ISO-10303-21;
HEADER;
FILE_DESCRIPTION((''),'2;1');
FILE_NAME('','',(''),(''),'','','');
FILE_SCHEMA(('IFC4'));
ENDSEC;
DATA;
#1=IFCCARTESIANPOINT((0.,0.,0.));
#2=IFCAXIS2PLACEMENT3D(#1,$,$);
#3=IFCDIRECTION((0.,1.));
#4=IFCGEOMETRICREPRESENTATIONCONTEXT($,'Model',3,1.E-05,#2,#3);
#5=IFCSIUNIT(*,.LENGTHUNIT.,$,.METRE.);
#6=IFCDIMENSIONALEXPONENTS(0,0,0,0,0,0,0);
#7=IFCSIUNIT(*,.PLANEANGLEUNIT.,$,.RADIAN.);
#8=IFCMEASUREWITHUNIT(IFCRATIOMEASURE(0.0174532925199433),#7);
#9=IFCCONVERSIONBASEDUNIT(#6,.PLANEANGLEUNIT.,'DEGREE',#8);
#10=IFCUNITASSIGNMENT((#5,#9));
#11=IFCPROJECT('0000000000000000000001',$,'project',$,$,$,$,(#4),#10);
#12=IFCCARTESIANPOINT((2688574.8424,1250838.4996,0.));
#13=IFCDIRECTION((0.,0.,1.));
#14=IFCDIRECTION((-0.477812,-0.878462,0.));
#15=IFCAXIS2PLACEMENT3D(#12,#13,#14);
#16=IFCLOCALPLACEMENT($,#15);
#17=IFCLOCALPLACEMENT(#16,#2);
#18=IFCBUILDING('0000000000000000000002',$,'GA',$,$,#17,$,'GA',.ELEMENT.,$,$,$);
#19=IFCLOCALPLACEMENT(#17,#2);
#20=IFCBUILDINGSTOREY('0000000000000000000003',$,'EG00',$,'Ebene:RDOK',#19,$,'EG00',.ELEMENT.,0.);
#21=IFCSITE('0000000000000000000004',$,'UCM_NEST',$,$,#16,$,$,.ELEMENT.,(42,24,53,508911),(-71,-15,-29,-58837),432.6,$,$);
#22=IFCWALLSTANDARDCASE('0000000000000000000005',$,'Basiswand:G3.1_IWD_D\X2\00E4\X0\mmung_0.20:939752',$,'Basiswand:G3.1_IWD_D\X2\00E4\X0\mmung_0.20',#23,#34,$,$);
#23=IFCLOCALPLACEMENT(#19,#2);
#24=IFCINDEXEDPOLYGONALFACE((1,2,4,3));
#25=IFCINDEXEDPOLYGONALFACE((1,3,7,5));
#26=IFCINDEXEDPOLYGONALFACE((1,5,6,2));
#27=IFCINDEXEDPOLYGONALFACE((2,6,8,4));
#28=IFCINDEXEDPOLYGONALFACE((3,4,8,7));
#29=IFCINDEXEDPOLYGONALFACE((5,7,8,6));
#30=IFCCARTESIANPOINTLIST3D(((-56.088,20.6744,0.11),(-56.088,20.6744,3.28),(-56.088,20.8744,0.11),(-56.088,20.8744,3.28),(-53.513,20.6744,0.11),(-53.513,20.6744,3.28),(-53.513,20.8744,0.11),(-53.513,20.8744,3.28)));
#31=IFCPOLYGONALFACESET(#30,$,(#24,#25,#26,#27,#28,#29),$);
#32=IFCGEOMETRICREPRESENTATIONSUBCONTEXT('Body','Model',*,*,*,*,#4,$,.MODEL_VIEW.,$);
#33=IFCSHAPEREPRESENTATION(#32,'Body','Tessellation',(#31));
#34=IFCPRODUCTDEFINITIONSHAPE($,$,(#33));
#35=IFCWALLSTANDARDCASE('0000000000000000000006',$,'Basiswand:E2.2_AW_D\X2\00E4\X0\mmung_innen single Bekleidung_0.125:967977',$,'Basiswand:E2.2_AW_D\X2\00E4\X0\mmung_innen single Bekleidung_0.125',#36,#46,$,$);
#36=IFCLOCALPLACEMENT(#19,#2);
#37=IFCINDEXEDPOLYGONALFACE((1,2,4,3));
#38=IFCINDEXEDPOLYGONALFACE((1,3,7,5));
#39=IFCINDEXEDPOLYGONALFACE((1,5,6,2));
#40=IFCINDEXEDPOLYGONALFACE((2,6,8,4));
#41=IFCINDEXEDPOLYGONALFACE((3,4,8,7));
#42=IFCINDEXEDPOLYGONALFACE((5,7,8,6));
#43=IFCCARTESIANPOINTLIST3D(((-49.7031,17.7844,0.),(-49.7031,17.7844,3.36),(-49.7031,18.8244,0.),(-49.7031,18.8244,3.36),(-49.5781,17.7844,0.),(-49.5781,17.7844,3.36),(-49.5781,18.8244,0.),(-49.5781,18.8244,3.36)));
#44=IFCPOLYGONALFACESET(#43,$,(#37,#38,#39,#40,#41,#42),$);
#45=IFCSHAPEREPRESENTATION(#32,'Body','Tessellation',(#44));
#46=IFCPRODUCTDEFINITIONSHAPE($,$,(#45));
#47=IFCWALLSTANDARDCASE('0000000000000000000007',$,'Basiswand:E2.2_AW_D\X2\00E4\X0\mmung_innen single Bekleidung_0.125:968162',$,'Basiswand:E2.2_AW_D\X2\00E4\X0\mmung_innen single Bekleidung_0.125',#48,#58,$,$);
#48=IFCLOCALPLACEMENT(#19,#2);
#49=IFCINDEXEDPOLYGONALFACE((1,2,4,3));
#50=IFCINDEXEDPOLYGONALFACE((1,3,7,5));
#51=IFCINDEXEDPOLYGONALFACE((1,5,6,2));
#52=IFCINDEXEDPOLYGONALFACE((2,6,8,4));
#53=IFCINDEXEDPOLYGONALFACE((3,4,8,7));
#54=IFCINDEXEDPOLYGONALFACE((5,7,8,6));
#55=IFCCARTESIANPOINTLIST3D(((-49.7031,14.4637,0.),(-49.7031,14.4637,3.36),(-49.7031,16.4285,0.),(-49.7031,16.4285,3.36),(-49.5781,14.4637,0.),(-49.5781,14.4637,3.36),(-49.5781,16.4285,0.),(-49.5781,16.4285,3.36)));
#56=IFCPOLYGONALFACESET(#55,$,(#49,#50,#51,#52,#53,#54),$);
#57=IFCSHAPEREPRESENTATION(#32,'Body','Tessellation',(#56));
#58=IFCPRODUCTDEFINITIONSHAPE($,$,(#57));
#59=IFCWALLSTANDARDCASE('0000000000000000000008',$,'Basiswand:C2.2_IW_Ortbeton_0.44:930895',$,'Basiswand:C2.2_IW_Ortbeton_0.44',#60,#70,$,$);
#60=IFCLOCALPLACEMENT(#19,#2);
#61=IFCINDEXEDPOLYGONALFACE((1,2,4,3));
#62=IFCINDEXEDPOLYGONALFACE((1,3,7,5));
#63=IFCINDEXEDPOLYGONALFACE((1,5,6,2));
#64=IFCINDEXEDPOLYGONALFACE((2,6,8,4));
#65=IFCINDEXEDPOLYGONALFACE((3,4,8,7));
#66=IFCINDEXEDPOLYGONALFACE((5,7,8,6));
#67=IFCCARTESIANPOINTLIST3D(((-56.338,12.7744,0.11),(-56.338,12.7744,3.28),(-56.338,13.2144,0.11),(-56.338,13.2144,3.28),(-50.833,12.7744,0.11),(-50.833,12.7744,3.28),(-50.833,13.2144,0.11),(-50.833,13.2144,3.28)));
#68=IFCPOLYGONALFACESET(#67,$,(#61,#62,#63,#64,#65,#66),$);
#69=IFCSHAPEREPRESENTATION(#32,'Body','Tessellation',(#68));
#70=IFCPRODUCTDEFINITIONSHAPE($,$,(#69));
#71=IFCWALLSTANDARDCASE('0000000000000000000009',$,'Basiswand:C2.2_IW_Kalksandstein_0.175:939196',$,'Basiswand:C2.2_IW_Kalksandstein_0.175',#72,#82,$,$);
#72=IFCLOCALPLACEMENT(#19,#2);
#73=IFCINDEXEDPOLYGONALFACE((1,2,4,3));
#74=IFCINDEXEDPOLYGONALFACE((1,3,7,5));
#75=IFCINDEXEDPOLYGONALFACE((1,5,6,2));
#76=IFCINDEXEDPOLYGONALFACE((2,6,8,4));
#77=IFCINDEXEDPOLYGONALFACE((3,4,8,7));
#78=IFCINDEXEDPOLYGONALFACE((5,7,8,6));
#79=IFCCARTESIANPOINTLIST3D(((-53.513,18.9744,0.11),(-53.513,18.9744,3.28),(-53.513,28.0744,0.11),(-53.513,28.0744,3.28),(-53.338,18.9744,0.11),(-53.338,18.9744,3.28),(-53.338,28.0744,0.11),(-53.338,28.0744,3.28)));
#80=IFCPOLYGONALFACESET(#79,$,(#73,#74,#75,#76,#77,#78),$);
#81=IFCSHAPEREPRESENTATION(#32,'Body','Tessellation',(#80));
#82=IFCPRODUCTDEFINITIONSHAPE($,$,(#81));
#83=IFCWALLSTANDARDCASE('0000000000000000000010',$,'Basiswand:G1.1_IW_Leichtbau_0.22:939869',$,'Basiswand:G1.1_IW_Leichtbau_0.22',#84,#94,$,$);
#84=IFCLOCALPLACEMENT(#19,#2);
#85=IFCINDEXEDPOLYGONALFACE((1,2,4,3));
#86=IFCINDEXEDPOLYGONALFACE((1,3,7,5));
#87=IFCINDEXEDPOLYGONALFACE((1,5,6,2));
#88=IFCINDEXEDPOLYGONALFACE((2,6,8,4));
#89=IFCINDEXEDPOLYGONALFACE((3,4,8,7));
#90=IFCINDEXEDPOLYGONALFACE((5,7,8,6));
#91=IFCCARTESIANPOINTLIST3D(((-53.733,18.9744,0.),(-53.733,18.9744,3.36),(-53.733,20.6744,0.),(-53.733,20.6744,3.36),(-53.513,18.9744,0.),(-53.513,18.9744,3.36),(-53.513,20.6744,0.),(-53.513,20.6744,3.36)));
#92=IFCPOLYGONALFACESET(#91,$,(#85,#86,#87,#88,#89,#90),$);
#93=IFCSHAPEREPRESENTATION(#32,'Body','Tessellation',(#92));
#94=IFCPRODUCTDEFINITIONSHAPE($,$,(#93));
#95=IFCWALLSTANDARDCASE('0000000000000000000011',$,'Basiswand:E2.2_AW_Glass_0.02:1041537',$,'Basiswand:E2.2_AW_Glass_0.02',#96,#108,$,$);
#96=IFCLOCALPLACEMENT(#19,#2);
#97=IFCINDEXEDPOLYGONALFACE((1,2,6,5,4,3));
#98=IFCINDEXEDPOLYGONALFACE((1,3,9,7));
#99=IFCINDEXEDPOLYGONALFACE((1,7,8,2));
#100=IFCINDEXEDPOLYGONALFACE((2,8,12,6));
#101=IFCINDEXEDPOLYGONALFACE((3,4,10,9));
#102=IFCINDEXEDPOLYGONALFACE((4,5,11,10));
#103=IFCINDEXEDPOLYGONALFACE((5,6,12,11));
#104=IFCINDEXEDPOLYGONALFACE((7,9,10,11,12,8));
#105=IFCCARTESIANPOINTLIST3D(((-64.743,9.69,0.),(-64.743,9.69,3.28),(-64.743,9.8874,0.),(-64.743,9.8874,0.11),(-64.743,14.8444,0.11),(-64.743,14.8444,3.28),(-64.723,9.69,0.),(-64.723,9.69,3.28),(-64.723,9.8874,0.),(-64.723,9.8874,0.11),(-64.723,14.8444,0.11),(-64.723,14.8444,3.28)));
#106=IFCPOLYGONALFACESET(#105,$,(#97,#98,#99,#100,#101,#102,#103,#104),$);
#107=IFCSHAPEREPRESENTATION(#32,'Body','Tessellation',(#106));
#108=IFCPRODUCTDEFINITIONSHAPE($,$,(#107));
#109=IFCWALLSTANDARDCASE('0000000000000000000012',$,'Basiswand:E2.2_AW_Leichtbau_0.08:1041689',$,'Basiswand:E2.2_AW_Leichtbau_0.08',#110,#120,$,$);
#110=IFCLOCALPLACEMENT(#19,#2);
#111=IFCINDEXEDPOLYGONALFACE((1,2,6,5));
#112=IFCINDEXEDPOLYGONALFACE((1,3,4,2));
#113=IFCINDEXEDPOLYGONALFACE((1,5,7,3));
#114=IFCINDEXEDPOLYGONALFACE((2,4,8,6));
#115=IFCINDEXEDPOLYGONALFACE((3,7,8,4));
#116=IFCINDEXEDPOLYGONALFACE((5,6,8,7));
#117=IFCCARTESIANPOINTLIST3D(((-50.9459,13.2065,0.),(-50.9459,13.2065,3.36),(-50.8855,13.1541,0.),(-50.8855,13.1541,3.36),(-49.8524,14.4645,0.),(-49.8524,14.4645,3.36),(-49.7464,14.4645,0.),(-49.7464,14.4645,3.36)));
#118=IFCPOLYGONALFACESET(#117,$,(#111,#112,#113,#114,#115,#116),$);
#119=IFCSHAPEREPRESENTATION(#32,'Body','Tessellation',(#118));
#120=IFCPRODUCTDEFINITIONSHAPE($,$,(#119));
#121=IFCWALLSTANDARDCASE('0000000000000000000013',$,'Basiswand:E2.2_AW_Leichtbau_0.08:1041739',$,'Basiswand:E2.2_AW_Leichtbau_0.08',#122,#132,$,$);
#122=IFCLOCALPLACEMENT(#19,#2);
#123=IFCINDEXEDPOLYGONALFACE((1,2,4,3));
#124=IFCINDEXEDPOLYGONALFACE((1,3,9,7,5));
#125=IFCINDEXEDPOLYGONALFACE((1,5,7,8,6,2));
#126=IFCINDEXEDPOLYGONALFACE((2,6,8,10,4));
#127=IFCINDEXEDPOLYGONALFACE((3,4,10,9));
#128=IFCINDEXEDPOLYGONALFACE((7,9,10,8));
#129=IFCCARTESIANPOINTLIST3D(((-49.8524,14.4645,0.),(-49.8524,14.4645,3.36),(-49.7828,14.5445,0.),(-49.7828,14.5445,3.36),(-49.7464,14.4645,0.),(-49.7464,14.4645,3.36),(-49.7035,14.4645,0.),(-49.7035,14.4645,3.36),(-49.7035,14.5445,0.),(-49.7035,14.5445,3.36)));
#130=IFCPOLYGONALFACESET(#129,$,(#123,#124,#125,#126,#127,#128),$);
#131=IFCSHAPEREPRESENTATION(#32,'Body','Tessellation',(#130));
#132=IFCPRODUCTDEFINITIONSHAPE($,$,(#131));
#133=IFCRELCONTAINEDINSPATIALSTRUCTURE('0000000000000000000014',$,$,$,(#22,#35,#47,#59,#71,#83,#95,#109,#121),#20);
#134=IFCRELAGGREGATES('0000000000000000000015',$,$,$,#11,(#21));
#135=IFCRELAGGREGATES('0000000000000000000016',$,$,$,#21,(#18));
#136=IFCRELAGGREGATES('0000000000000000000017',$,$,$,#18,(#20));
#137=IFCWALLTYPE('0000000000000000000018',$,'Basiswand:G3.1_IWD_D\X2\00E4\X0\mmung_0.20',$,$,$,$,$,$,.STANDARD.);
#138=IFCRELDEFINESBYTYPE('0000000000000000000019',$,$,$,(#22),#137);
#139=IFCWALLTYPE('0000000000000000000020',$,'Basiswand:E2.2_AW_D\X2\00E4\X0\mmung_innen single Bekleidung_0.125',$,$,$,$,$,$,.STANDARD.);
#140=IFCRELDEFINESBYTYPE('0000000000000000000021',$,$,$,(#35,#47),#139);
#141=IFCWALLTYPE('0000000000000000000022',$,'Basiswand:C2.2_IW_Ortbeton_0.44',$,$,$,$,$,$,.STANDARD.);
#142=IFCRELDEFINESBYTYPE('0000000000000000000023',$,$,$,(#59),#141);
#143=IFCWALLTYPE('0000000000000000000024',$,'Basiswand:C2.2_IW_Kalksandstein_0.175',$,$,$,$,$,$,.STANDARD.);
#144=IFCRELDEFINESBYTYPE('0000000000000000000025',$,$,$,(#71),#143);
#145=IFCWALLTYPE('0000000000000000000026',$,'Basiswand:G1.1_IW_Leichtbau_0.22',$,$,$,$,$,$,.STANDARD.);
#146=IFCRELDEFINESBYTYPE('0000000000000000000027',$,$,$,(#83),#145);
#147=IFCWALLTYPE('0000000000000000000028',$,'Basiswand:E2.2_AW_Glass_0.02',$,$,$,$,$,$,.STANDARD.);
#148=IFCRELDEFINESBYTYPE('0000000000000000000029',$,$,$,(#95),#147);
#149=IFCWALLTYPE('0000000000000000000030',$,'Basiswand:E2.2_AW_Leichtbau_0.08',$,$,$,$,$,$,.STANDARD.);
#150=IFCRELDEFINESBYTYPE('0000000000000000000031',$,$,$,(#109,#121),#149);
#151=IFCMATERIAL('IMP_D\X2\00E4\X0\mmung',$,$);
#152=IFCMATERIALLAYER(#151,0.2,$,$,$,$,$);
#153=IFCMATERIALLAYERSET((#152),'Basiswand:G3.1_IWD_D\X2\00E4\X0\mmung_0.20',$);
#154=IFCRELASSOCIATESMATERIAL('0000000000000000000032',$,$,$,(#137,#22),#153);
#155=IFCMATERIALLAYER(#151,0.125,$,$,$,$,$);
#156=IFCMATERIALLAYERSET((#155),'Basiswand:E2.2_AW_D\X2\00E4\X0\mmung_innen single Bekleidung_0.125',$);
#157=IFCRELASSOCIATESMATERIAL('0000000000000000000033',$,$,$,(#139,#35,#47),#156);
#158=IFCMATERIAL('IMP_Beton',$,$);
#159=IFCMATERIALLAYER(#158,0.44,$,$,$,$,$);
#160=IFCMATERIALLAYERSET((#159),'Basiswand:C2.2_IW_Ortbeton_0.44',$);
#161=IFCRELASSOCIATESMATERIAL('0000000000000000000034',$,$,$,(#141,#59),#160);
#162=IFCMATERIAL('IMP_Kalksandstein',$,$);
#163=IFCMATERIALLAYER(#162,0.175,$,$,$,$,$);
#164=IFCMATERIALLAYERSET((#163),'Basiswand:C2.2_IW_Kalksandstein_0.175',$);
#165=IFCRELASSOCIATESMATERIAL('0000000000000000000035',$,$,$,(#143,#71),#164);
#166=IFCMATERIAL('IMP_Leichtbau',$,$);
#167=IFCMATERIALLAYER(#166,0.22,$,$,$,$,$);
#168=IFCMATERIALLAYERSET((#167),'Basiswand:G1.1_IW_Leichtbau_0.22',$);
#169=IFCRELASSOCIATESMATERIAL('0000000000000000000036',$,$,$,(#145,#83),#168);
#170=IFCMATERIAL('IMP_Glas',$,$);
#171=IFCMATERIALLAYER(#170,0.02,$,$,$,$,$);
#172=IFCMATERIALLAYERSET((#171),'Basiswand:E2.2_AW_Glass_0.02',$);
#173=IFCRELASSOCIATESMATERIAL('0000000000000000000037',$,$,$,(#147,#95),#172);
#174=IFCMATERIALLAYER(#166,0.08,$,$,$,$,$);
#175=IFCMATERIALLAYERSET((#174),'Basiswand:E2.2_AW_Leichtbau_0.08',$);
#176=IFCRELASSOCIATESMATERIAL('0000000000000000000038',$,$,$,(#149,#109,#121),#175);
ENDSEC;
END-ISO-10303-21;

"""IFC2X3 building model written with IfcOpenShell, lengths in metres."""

from ifc_helpers import new_model, entity, si_unit, converted_unit, direction, frame, frame_2d, origin, place, context, subcontext, project, spatial, polyline, rectangle, outline, extrude, clip, bounded_halfspace, material, layer, layer_set, layer_usage, type_object, element, save


model = new_model("IFC2X3")

# Units and contexts
model_context = context("Model", 3, precision=1e-05, world=origin(), true_north=direction((0.0, 1.0)))
body_context = subcontext(model_context, "Body", "Model", "MODEL_VIEW")
ifc_project = project(units=[si_unit("LENGTHUNIT", "METRE"), converted_unit("PLANEANGLEUNIT", "DEGREE", entity("IfcRatioMeasure", 0.0174532925199433), si_unit("PLANEANGLEUNIT", "RADIAN"), dimensions=[0, 0, 0, 0, 0, 0, 0])], contexts=[model_context])

# Site, building, storey
site_placement = place(None, frame((2688574.8424, 1250838.4996, 0.0), z_axis=(0.0, 0.0, 1.0), x_axis=(-0.477812, -0.878462, 0.0)))
site = spatial("IfcSite", under=ifc_project, at=site_placement, Name="UCM_NEST", CompositionType="ELEMENT", RefLatitude=(42, 24, 53, 508911), RefLongitude=(-71, -15, -29, -58837), RefElevation=432.6)
building_placement = place(site_placement, origin())
building = spatial("IfcBuilding", under=site, at=building_placement, Name="GA", LongName="GA", CompositionType="ELEMENT")
storey_placement = place(building_placement, origin())
storey = spatial("IfcBuildingStorey", under=building, at=storey_placement, Name="EG00", ObjectType="Ebene:RDOK", LongName="EG00", CompositionType="ELEMENT", Elevation=0.0)

# Shared definitions
ifc_material_1 = material(Name="IMP_Beton")

# Shared definitions
ifc_material_2 = material(Name="IMP_Glas")

# Shared definitions
ifc_material_3 = material(Name="IMP_Dämmung")

# Walls
ifc_layer_1 = layer(ifc_material_3, 0.2)
ifc_layer_set_1 = layer_set([ifc_layer_1], Name="Basiswand:G3.1_IWD_Dämmung_0.20")
ifc_layer_usage_1 = layer_usage(ifc_layer_set_1, "AXIS2", "NEGATIVE", 0.1)
wall_type_1 = type_object("IfcWallType", Name="Basiswand:G3.1_IWD_Dämmung_0.20", PredefinedType="STANDARD", material=ifc_layer_set_1)
wall_1_placement = place(storey_placement, frame((-53.513, 20.7744, 0.11), z_axis=(0.0, 0.0, 1.0), x_axis=(-1.0, 0.0, 0.0)))
element("IfcWallStandardCase", 1, at=wall_1_placement, inside=storey, type_object=wall_type_1, material=ifc_layer_usage_1, Name="Basiswand:G3.1_IWD_Dämmung_0.20:939752", ObjectType="Basiswand:G3.1_IWD_Dämmung_0.20", context=body_context, shape_type="Clipping", body=[
    clip(extrude(rectangle(XDim=2.575, YDim=0.2, at=frame_2d((1.2875, 0.0), x_axis=(-1.0, 0.0))), origin(), (0.0, 0.0, 1.0), 3.17), bounded_halfspace(frame((2.575, -0.1, 0.0)), True, frame((2.575, -0.1, 0.0)), polyline([(0.0, 0.0), (0.0, 0.2), (-2.575, 0.2), (-2.575, 0.0), (0.0, 0.0)]))),
])
ifc_layer_2 = layer(ifc_material_3, 0.125)
ifc_layer_set_2 = layer_set([ifc_layer_2], Name="Basiswand:E2.2_AW_Dämmung_innen single Bekleidung_0.125")
ifc_layer_usage_2 = layer_usage(ifc_layer_set_2, "AXIS2", "NEGATIVE", 0.0625)
wall_type_2 = type_object("IfcWallType", Name="Basiswand:E2.2_AW_Dämmung_innen single Bekleidung_0.125", PredefinedType="STANDARD", material=ifc_layer_set_2)
wall_2_placement = place(storey_placement, frame((-49.6406, 18.8244, 0.0), z_axis=(0.0, 0.0, 1.0), x_axis=(0.0, -1.0, 0.0)))
element("IfcWallStandardCase", 2, at=wall_2_placement, inside=storey, type_object=wall_type_2, material=ifc_layer_usage_2, Name="Basiswand:E2.2_AW_Dämmung_innen single Bekleidung_0.125:967977", ObjectType="Basiswand:E2.2_AW_Dämmung_innen single Bekleidung_0.125", context=body_context, shape_type="SweptSolid", body=[
    extrude(rectangle(XDim=1.04, YDim=0.125, at=frame_2d((0.52, 0.0), x_axis=(-1.0, 0.0))), origin(), (0.0, 0.0, 1.0), 3.36),
])
ifc_layer_usage_3 = layer_usage(ifc_layer_set_2, "AXIS2", "NEGATIVE", 0.0625)
wall_3_placement = place(storey_placement, frame((-49.6406, 16.4285, 0.0), z_axis=(0.0, 0.0, 1.0), x_axis=(0.0, -1.0, 0.0)))
element("IfcWallStandardCase", 3, at=wall_3_placement, inside=storey, type_object=wall_type_2, material=ifc_layer_usage_3, Name="Basiswand:E2.2_AW_Dämmung_innen single Bekleidung_0.125:968162", ObjectType="Basiswand:E2.2_AW_Dämmung_innen single Bekleidung_0.125", context=body_context, shape_type="SweptSolid", body=[
    extrude(rectangle(XDim=1.9648, YDim=0.125, at=frame_2d((0.9824, 0.0), x_axis=(-1.0, 0.0))), origin(), (0.0, 0.0, 1.0), 3.36),
])
ifc_layer_3 = layer(ifc_material_1, 0.44)
ifc_layer_set_3 = layer_set([ifc_layer_3], Name="Basiswand:C2.2_IW_Ortbeton_0.44")
ifc_layer_usage_4 = layer_usage(ifc_layer_set_3, "AXIS2", "NEGATIVE", 0.22)
wall_type_3 = type_object("IfcWallType", Name="Basiswand:C2.2_IW_Ortbeton_0.44", PredefinedType="STANDARD", material=ifc_layer_set_3)
wall_4_placement = place(storey_placement, frame((-50.833, 12.9944, 0.11), z_axis=(0.0, 0.0, 1.0), x_axis=(-1.0, 0.0, 0.0)))
element("IfcWallStandardCase", 4, at=wall_4_placement, inside=storey, type_object=wall_type_3, material=ifc_layer_usage_4, Name="Basiswand:C2.2_IW_Ortbeton_0.44:930895", ObjectType="Basiswand:C2.2_IW_Ortbeton_0.44", context=body_context, shape_type="Clipping", body=[
    clip(clip(extrude(rectangle(XDim=5.505, YDim=0.44, at=frame_2d((2.7525, 0.0), x_axis=(-1.0, 0.0))), origin(), (0.0, 0.0, 1.0), 3.17), bounded_halfspace(frame((5.505, -0.22, 0.0)), True, frame((5.505, -0.22, 0.0)), polyline([(0.0, 0.0), (0.0, 0.44), (-5.505, 0.44), (-5.505, 0.0), (-0.25, 0.0), (0.0, 0.0)]))), bounded_halfspace(frame((0.0, -0.22, 3.17), z_axis=(0.0, 0.0, -1.0), x_axis=(1.0, 0.0, 0.0)), True, frame((0.0, -0.22, 3.17), z_axis=(0.0, 0.0, -1.0), x_axis=(1.0, 0.0, 0.0)), polyline([(0.0, 0.0), (0.0, -0.44), (5.505, -0.44), (5.505, 0.0), (0.0, 0.0)]))),
])
ifc_material_4 = material(Name="IMP_Kalksandstein")
ifc_layer_4 = layer(ifc_material_4, 0.175)
ifc_layer_set_4 = layer_set([ifc_layer_4], Name="Basiswand:C2.2_IW_Kalksandstein_0.175")
ifc_layer_usage_5 = layer_usage(ifc_layer_set_4, "AXIS2", "NEGATIVE", 0.0875)
wall_type_4 = type_object("IfcWallType", Name="Basiswand:C2.2_IW_Kalksandstein_0.175", PredefinedType="STANDARD", material=ifc_layer_set_4)
wall_5_placement = place(storey_placement, frame((-53.4255, 18.9744, 0.11), z_axis=(0.0, 0.0, 1.0), x_axis=(0.0, 1.0, 0.0)))
element("IfcWallStandardCase", 5, at=wall_5_placement, inside=storey, type_object=wall_type_4, material=ifc_layer_usage_5, Name="Basiswand:C2.2_IW_Kalksandstein_0.175:939196", ObjectType="Basiswand:C2.2_IW_Kalksandstein_0.175", context=body_context, shape_type="Clipping", body=[
    clip(clip(extrude(rectangle(XDim=9.1, YDim=0.175, at=frame_2d((4.55, 0.0), x_axis=(-1.0, 0.0))), origin(), (0.0, 0.0, 1.0), 3.17), bounded_halfspace(frame((9.1, -0.0875, 0.0), z_axis=(0.0, 0.0, 1.0), x_axis=(0.0, 1.0, 0.0)), True, frame((9.1, -0.0875, 0.0), z_axis=(0.0, 0.0, 1.0), x_axis=(0.0, 1.0, 0.0)), polyline([(0.0, 0.0), (0.175, 0.0), (0.175, 7.2), (0.175, 7.4), (0.175, 9.1), (0.0, 9.1), (0.0, 0.0)]))), bounded_halfspace(frame((0.0, -0.0875, 3.17), z_axis=(0.0, 0.0, -1.0), x_axis=(0.0, 1.0, 0.0)), True, frame((0.0, -0.0875, 3.17), z_axis=(0.0, 0.0, -1.0), x_axis=(0.0, 1.0, 0.0)), polyline([(0.0, 0.0), (0.175, 0.0), (0.175, 1.7), (0.175, 1.9), (0.175, 9.1), (0.0, 9.1), (0.0, 0.0)]))),
])
ifc_material_5 = material(Name="IMP_Leichtbau")
ifc_layer_5 = layer(ifc_material_5, 0.22)
ifc_layer_set_5 = layer_set([ifc_layer_5], Name="Basiswand:G1.1_IW_Leichtbau_0.22")
ifc_layer_usage_6 = layer_usage(ifc_layer_set_5, "AXIS2", "NEGATIVE", 0.11)
wall_type_5 = type_object("IfcWallType", Name="Basiswand:G1.1_IW_Leichtbau_0.22", PredefinedType="STANDARD", material=ifc_layer_set_5)
wall_6_placement = place(storey_placement, frame((-53.623, 20.6744, 0.0), z_axis=(0.0, 0.0, 1.0), x_axis=(0.0, -1.0, 0.0)))
element("IfcWallStandardCase", 6, at=wall_6_placement, inside=storey, type_object=wall_type_5, material=ifc_layer_usage_6, Name="Basiswand:G1.1_IW_Leichtbau_0.22:939869", ObjectType="Basiswand:G1.1_IW_Leichtbau_0.22", context=body_context, shape_type="SweptSolid", body=[
    extrude(rectangle(XDim=1.7, YDim=0.22, at=frame_2d((0.85, 0.0), x_axis=(-1.0, 0.0))), origin(), (0.0, 0.0, 1.0), 3.36),
])

# Walls
ifc_layer_6 = layer(ifc_material_2, 0.02)
ifc_layer_set_6 = layer_set([ifc_layer_6], Name="Basiswand:E2.2_AW_Glass_0.02")
ifc_layer_usage_7 = layer_usage(ifc_layer_set_6, "AXIS2", "NEGATIVE", 0.01)
wall_type_6 = type_object("IfcWallType", Name="Basiswand:E2.2_AW_Glass_0.02", PredefinedType="STANDARD", material=ifc_layer_set_6)
wall_7_placement = place(storey_placement, frame((-64.733, 14.8444, 0.0), z_axis=(0.0, 0.0, 1.0), x_axis=(0.0, -1.0, 0.0)))
element("IfcWallStandardCase", 7, at=wall_7_placement, inside=storey, type_object=wall_type_6, material=ifc_layer_usage_7, Name="Basiswand:E2.2_AW_Glass_0.02:1041537", ObjectType="Basiswand:E2.2_AW_Glass_0.02", context=body_context, shape_type="Clipping", body=[
    clip(clip(clip(extrude(rectangle(XDim=5.1545, YDim=0.02, at=frame_2d((2.5772, 0.0), x_axis=(-1.0, 0.0))), origin(), (0.0, 0.0, 1.0), 3.28), bounded_halfspace(frame((4.957, 0.01, 0.11), z_axis=(0.0, 0.0, 1.0), x_axis=(0.0, -1.0, 0.0)), True, frame((4.957, 0.01, 0.11), z_axis=(0.0, 0.0, 1.0), x_axis=(0.0, -1.0, 0.0)), polyline([(0.0, 0.0), (0.0, -4.957), (0.02, -4.957), (0.02, 0.0), (0.0, 0.0)]))), bounded_halfspace(frame((4.957, -0.01, 0.11), z_axis=(1.0, 0.0, 0.0), x_axis=(0.0, 0.0, 1.0)), True, frame((4.957, -0.01, 0.11), z_axis=(1.0, 0.0, 0.0), x_axis=(0.0, 0.0, 1.0)), polyline([(0.0, 0.0), (-0.11, 0.0), (-0.11, -0.02), (0.0, -0.02), (0.0, 0.0)]))), bounded_halfspace(frame((0.0, -0.01, 3.28), z_axis=(0.0, 0.0, -1.0), x_axis=(0.0, -1.0, 0.0)), True, frame((0.0, -0.01, 3.28), z_axis=(0.0, 0.0, -1.0), x_axis=(0.0, -1.0, 0.0)), polyline([(0.0, 0.0), (-0.02, 0.0), (-0.02, -5.1545), (0.0, -5.1545), (0.0, 0.0)]))),
])
ifc_layer_7 = layer(ifc_material_5, 0.08)
ifc_layer_set_7 = layer_set([ifc_layer_7], Name="Basiswand:E2.2_AW_Leichtbau_0.08")
ifc_layer_usage_8 = layer_usage(ifc_layer_set_7, "AXIS2", "NEGATIVE", 0.04)
wall_type_7 = type_object("IfcWallType", Name="Basiswand:E2.2_AW_Leichtbau_0.08", PredefinedType="STANDARD", material=ifc_layer_set_7)
wall_8_placement = place(storey_placement, frame((-50.9157, 13.1803, 0.0), z_axis=(0.0, 0.0, 1.0), x_axis=(0.656059, 0.75471, 0.0)))
element("IfcWallStandardCase", 8, at=wall_8_placement, inside=storey, type_object=wall_type_7, material=ifc_layer_usage_8, Name="Basiswand:E2.2_AW_Leichtbau_0.08:1041689", ObjectType="Basiswand:E2.2_AW_Leichtbau_0.08", context=body_context, shape_type="SweptSolid", body=[
    extrude(outline(polyline([(1.7363, -0.04), (1.6667, 0.04), (0.0, 0.04), (0.0, -0.04), (1.7363, -0.04)])), origin(), (0.0, 0.0, 1.0), 3.36),
])
ifc_layer_usage_9 = layer_usage(ifc_layer_set_7, "AXIS2", "NEGATIVE", 0.04)
wall_9_placement = place(storey_placement, frame((-49.7035, 14.5045, 0.0), z_axis=(0.0, 0.0, 1.0), x_axis=(-1.0, 0.0, 0.0)))
element("IfcWallStandardCase", 9, at=wall_9_placement, inside=storey, type_object=wall_type_7, material=ifc_layer_usage_9, Name="Basiswand:E2.2_AW_Leichtbau_0.08:1041739", ObjectType="Basiswand:E2.2_AW_Leichtbau_0.08", context=body_context, shape_type="SweptSolid", body=[
    extrude(outline(polyline([(0.0793, -0.04), (0.1489, 0.04), (0.0429, 0.04), (0.0, 0.04), (0.0, -0.04), (0.0793, -0.04)])), origin(), (0.0, 0.0, 1.0), 3.36),
])

save(model, "model.ifc")
